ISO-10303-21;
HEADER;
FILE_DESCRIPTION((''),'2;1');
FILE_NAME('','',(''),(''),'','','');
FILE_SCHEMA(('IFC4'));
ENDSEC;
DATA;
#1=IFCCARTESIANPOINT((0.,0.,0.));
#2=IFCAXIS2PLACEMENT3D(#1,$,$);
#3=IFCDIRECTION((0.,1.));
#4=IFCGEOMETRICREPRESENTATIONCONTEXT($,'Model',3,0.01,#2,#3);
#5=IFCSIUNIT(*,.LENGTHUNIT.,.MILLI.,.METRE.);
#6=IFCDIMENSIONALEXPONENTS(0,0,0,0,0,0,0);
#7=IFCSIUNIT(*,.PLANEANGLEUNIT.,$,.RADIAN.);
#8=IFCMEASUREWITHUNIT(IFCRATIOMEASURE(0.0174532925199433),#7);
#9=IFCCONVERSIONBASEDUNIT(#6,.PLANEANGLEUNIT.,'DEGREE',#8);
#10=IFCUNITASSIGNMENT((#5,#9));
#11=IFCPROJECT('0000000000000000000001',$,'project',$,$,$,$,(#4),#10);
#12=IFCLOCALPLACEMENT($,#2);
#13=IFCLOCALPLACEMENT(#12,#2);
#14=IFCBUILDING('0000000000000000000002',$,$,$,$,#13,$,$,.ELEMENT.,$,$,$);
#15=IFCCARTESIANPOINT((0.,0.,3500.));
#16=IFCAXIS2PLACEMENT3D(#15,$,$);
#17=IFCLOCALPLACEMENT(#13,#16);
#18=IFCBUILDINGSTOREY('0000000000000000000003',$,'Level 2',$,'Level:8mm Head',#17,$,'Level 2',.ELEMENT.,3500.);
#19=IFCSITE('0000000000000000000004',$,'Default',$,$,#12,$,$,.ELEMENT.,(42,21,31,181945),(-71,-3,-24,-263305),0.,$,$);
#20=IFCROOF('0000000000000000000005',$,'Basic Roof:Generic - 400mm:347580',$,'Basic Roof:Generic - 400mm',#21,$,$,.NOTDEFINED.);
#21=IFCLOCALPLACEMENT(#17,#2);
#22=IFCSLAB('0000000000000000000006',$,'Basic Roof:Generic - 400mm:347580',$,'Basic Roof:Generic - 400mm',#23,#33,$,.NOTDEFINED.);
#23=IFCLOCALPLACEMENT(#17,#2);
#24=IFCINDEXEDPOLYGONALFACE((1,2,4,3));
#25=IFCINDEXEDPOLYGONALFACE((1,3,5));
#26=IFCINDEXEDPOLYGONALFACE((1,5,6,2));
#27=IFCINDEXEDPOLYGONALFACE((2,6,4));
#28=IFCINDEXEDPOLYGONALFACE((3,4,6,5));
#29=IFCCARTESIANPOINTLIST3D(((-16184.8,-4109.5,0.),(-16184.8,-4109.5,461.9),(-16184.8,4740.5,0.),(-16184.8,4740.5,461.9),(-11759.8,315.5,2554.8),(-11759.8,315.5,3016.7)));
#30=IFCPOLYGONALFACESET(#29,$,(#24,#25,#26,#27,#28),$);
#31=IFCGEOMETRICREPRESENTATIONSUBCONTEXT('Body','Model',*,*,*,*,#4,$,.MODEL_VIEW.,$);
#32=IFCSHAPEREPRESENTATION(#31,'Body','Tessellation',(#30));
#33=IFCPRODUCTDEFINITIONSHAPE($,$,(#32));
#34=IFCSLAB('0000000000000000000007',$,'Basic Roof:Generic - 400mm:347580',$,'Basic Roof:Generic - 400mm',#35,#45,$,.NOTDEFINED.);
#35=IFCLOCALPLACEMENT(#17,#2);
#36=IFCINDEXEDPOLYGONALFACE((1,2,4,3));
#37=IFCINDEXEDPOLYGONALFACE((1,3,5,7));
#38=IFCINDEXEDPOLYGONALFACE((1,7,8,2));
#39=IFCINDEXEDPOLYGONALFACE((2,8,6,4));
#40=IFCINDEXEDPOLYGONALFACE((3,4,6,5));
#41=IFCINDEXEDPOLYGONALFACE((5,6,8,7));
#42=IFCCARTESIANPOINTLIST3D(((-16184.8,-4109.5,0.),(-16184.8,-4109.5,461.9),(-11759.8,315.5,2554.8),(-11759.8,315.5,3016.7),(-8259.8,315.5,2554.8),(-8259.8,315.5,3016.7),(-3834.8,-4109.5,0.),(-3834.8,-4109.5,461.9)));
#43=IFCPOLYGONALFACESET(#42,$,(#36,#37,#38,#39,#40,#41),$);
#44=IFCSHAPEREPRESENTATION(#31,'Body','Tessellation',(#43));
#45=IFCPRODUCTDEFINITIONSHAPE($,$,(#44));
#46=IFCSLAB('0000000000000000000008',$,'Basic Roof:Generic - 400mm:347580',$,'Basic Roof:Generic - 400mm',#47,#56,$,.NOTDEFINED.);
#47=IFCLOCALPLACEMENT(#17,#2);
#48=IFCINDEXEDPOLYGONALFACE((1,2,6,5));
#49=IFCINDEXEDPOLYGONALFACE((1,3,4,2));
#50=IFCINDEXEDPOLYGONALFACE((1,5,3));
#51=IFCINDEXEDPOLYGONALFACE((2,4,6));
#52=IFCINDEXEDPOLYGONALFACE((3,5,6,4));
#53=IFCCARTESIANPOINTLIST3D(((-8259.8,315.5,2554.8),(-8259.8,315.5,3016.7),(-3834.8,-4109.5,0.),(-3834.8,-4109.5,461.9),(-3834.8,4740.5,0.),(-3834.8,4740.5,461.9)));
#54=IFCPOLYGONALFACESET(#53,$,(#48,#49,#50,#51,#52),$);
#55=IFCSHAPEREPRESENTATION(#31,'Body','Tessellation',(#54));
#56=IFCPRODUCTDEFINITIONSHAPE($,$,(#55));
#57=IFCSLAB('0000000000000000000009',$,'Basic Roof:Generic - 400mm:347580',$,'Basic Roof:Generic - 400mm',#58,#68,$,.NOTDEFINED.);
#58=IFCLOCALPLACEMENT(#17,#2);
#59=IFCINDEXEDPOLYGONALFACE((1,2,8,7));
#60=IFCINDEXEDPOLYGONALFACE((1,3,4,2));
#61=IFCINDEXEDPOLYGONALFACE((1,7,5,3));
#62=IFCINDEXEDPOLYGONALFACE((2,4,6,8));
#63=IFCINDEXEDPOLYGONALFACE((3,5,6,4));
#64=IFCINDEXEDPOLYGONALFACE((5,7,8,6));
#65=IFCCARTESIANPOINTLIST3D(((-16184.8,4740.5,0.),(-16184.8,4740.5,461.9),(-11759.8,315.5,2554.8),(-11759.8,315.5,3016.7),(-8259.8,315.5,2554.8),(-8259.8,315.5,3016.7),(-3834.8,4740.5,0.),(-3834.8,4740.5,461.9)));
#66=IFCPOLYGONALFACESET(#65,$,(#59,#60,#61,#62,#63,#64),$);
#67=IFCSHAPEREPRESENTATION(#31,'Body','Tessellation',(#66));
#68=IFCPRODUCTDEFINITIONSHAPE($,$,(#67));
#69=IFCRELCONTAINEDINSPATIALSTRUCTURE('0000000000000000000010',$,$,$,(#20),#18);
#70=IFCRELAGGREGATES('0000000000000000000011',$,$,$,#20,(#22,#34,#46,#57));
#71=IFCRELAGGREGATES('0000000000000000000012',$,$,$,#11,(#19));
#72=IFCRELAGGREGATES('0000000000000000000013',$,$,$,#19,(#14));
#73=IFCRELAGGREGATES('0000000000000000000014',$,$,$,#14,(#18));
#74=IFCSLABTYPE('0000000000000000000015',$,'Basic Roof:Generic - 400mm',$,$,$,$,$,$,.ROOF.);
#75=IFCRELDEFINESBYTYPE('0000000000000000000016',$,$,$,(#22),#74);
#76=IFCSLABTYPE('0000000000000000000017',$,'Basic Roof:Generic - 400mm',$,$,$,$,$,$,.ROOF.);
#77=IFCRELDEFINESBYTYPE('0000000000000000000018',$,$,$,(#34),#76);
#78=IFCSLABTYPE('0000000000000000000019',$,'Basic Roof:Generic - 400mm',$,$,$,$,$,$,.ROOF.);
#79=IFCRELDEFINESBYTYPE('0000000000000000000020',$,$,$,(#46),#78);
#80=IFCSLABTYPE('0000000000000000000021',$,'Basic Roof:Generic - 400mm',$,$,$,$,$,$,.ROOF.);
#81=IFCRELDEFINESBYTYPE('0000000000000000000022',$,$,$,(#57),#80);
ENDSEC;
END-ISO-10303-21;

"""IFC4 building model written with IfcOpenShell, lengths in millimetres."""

from ifc_helpers import new_model, entity, si_unit, converted_unit, direction, frame, origin, place, context, subcontext, project, spatial, polyline, outline, extrude, type_object, element, aggregate, save


model = new_model("IFC4")

# Units and contexts
model_context = context("Model", 3, precision=0.01, world=origin(), true_north=direction((0.0, 1.0)))
body_context = subcontext(model_context, "Body", "Model", "MODEL_VIEW")
ifc_project = project(units=[si_unit("LENGTHUNIT", "METRE", prefix="MILLI"), converted_unit("PLANEANGLEUNIT", "DEGREE", entity("IfcRatioMeasure", 0.0174532925199433), si_unit("PLANEANGLEUNIT", "RADIAN"), dimensions=[0, 0, 0, 0, 0, 0, 0])], contexts=[model_context])

# Site, building, storey
site_placement = place(None, origin())
site = spatial("IfcSite", under=ifc_project, at=site_placement, Name="Default", CompositionType="ELEMENT", RefLatitude=(42, 21, 31, 181945), RefLongitude=(-71, -3, -24, -263305), RefElevation=0.0)
building_placement = place(site_placement, origin())
building = spatial("IfcBuilding", under=site, at=building_placement, CompositionType="ELEMENT")
storey_placement = place(building_placement, frame((0.0, 0.0, 3500.0)))
storey = spatial("IfcBuildingStorey", under=building, at=storey_placement, Name="Level 2", ObjectType="Level:8mm Head", LongName="Level 2", CompositionType="ELEMENT", Elevation=3500.0)

# Roof, slabs
roof_placement = place(storey_placement, frame((-16184.8, -4109.5, 0.0)))
roof = element("IfcRoof", 1, at=roof_placement, inside=storey, Name="Basic Roof:Generic - 400mm:347580", ObjectType="Basic Roof:Generic - 400mm", PredefinedType="NOTDEFINED")
slab_type_1 = type_object("IfcSlabType", Name="Basic Roof:Generic - 400mm", PredefinedType="ROOF")
slab_1_placement = place(roof_placement, origin())
slab_1 = element("IfcSlab", 2, at=slab_1_placement, type_object=slab_type_1, Name="Basic Roof:Generic - 400mm:347580", ObjectType="Basic Roof:Generic - 400mm", PredefinedType="NOTDEFINED", context=body_context, shape_type="SweptSolid", body=[
    extrude(outline(polyline([(2554.8, 0.0), (-2554.8, 4425.0), (-2554.8, -4425.0), (2554.8, 0.0)])), frame((2212.5, 4425.0, 1277.4), z_axis=(-0.5, 0.0, 0.866025), x_axis=(0.866025, 0.0, 0.5)), (0.5, 0.0, 0.866025), 461.9),
])
slab_type_2 = type_object("IfcSlabType", Name="Basic Roof:Generic - 400mm", PredefinedType="ROOF")
slab_2_placement = place(roof_placement, origin())
slab_2 = element("IfcSlab", 3, at=slab_2_placement, type_object=slab_type_2, Name="Basic Roof:Generic - 400mm:347580", ObjectType="Basic Roof:Generic - 400mm", PredefinedType="NOTDEFINED", context=body_context, shape_type="SweptSolid", body=[
    extrude(outline(polyline([(-6175.0, -2554.8), (6175.0, -2554.8), (1750.0, 2554.8), (-1750.0, 2554.8), (-6175.0, -2554.8)])), frame((6175.0, 2212.5, 1277.4), z_axis=(0.0, -0.5, 0.866025), x_axis=(1.0, 0.0, 0.0)), (0.0, 0.5, 0.866025), 461.9),
])
slab_type_3 = type_object("IfcSlabType", Name="Basic Roof:Generic - 400mm", PredefinedType="ROOF")
slab_3_placement = place(roof_placement, origin())
slab_3 = element("IfcSlab", 4, at=slab_3_placement, type_object=slab_type_3, Name="Basic Roof:Generic - 400mm:347580", ObjectType="Basic Roof:Generic - 400mm", PredefinedType="NOTDEFINED", context=body_context, shape_type="SweptSolid", body=[
    extrude(outline(polyline([(2554.8, -4425.0), (2554.8, 4425.0), (-2554.8, 0.0), (2554.8, -4425.0)])), frame((10137.5, 4425.0, 1277.4), z_axis=(0.5, 0.0, 0.866025), x_axis=(0.866025, 0.0, -0.5)), (-0.5, 0.0, 0.866025), 461.9),
])
slab_type_4 = type_object("IfcSlabType", Name="Basic Roof:Generic - 400mm", PredefinedType="ROOF")
slab_4_placement = place(roof_placement, origin())
slab_4 = element("IfcSlab", 5, at=slab_4_placement, type_object=slab_type_4, Name="Basic Roof:Generic - 400mm:347580", ObjectType="Basic Roof:Generic - 400mm", PredefinedType="NOTDEFINED", context=body_context, shape_type="SweptSolid", body=[
    extrude(outline(polyline([(6175.0, 2554.8), (-6175.0, 2554.8), (-1750.0, -2554.8), (1750.0, -2554.8), (6175.0, 2554.8)])), frame((6175.0, 6637.5, 1277.4), z_axis=(0.0, 0.5, 0.866025), x_axis=(1.0, 0.0, 0.0)), (0.0, -0.5, 0.866025), 461.9),
])
aggregate(roof, [slab_1, slab_2, slab_3, slab_4])

save(model, "model.ifc")
